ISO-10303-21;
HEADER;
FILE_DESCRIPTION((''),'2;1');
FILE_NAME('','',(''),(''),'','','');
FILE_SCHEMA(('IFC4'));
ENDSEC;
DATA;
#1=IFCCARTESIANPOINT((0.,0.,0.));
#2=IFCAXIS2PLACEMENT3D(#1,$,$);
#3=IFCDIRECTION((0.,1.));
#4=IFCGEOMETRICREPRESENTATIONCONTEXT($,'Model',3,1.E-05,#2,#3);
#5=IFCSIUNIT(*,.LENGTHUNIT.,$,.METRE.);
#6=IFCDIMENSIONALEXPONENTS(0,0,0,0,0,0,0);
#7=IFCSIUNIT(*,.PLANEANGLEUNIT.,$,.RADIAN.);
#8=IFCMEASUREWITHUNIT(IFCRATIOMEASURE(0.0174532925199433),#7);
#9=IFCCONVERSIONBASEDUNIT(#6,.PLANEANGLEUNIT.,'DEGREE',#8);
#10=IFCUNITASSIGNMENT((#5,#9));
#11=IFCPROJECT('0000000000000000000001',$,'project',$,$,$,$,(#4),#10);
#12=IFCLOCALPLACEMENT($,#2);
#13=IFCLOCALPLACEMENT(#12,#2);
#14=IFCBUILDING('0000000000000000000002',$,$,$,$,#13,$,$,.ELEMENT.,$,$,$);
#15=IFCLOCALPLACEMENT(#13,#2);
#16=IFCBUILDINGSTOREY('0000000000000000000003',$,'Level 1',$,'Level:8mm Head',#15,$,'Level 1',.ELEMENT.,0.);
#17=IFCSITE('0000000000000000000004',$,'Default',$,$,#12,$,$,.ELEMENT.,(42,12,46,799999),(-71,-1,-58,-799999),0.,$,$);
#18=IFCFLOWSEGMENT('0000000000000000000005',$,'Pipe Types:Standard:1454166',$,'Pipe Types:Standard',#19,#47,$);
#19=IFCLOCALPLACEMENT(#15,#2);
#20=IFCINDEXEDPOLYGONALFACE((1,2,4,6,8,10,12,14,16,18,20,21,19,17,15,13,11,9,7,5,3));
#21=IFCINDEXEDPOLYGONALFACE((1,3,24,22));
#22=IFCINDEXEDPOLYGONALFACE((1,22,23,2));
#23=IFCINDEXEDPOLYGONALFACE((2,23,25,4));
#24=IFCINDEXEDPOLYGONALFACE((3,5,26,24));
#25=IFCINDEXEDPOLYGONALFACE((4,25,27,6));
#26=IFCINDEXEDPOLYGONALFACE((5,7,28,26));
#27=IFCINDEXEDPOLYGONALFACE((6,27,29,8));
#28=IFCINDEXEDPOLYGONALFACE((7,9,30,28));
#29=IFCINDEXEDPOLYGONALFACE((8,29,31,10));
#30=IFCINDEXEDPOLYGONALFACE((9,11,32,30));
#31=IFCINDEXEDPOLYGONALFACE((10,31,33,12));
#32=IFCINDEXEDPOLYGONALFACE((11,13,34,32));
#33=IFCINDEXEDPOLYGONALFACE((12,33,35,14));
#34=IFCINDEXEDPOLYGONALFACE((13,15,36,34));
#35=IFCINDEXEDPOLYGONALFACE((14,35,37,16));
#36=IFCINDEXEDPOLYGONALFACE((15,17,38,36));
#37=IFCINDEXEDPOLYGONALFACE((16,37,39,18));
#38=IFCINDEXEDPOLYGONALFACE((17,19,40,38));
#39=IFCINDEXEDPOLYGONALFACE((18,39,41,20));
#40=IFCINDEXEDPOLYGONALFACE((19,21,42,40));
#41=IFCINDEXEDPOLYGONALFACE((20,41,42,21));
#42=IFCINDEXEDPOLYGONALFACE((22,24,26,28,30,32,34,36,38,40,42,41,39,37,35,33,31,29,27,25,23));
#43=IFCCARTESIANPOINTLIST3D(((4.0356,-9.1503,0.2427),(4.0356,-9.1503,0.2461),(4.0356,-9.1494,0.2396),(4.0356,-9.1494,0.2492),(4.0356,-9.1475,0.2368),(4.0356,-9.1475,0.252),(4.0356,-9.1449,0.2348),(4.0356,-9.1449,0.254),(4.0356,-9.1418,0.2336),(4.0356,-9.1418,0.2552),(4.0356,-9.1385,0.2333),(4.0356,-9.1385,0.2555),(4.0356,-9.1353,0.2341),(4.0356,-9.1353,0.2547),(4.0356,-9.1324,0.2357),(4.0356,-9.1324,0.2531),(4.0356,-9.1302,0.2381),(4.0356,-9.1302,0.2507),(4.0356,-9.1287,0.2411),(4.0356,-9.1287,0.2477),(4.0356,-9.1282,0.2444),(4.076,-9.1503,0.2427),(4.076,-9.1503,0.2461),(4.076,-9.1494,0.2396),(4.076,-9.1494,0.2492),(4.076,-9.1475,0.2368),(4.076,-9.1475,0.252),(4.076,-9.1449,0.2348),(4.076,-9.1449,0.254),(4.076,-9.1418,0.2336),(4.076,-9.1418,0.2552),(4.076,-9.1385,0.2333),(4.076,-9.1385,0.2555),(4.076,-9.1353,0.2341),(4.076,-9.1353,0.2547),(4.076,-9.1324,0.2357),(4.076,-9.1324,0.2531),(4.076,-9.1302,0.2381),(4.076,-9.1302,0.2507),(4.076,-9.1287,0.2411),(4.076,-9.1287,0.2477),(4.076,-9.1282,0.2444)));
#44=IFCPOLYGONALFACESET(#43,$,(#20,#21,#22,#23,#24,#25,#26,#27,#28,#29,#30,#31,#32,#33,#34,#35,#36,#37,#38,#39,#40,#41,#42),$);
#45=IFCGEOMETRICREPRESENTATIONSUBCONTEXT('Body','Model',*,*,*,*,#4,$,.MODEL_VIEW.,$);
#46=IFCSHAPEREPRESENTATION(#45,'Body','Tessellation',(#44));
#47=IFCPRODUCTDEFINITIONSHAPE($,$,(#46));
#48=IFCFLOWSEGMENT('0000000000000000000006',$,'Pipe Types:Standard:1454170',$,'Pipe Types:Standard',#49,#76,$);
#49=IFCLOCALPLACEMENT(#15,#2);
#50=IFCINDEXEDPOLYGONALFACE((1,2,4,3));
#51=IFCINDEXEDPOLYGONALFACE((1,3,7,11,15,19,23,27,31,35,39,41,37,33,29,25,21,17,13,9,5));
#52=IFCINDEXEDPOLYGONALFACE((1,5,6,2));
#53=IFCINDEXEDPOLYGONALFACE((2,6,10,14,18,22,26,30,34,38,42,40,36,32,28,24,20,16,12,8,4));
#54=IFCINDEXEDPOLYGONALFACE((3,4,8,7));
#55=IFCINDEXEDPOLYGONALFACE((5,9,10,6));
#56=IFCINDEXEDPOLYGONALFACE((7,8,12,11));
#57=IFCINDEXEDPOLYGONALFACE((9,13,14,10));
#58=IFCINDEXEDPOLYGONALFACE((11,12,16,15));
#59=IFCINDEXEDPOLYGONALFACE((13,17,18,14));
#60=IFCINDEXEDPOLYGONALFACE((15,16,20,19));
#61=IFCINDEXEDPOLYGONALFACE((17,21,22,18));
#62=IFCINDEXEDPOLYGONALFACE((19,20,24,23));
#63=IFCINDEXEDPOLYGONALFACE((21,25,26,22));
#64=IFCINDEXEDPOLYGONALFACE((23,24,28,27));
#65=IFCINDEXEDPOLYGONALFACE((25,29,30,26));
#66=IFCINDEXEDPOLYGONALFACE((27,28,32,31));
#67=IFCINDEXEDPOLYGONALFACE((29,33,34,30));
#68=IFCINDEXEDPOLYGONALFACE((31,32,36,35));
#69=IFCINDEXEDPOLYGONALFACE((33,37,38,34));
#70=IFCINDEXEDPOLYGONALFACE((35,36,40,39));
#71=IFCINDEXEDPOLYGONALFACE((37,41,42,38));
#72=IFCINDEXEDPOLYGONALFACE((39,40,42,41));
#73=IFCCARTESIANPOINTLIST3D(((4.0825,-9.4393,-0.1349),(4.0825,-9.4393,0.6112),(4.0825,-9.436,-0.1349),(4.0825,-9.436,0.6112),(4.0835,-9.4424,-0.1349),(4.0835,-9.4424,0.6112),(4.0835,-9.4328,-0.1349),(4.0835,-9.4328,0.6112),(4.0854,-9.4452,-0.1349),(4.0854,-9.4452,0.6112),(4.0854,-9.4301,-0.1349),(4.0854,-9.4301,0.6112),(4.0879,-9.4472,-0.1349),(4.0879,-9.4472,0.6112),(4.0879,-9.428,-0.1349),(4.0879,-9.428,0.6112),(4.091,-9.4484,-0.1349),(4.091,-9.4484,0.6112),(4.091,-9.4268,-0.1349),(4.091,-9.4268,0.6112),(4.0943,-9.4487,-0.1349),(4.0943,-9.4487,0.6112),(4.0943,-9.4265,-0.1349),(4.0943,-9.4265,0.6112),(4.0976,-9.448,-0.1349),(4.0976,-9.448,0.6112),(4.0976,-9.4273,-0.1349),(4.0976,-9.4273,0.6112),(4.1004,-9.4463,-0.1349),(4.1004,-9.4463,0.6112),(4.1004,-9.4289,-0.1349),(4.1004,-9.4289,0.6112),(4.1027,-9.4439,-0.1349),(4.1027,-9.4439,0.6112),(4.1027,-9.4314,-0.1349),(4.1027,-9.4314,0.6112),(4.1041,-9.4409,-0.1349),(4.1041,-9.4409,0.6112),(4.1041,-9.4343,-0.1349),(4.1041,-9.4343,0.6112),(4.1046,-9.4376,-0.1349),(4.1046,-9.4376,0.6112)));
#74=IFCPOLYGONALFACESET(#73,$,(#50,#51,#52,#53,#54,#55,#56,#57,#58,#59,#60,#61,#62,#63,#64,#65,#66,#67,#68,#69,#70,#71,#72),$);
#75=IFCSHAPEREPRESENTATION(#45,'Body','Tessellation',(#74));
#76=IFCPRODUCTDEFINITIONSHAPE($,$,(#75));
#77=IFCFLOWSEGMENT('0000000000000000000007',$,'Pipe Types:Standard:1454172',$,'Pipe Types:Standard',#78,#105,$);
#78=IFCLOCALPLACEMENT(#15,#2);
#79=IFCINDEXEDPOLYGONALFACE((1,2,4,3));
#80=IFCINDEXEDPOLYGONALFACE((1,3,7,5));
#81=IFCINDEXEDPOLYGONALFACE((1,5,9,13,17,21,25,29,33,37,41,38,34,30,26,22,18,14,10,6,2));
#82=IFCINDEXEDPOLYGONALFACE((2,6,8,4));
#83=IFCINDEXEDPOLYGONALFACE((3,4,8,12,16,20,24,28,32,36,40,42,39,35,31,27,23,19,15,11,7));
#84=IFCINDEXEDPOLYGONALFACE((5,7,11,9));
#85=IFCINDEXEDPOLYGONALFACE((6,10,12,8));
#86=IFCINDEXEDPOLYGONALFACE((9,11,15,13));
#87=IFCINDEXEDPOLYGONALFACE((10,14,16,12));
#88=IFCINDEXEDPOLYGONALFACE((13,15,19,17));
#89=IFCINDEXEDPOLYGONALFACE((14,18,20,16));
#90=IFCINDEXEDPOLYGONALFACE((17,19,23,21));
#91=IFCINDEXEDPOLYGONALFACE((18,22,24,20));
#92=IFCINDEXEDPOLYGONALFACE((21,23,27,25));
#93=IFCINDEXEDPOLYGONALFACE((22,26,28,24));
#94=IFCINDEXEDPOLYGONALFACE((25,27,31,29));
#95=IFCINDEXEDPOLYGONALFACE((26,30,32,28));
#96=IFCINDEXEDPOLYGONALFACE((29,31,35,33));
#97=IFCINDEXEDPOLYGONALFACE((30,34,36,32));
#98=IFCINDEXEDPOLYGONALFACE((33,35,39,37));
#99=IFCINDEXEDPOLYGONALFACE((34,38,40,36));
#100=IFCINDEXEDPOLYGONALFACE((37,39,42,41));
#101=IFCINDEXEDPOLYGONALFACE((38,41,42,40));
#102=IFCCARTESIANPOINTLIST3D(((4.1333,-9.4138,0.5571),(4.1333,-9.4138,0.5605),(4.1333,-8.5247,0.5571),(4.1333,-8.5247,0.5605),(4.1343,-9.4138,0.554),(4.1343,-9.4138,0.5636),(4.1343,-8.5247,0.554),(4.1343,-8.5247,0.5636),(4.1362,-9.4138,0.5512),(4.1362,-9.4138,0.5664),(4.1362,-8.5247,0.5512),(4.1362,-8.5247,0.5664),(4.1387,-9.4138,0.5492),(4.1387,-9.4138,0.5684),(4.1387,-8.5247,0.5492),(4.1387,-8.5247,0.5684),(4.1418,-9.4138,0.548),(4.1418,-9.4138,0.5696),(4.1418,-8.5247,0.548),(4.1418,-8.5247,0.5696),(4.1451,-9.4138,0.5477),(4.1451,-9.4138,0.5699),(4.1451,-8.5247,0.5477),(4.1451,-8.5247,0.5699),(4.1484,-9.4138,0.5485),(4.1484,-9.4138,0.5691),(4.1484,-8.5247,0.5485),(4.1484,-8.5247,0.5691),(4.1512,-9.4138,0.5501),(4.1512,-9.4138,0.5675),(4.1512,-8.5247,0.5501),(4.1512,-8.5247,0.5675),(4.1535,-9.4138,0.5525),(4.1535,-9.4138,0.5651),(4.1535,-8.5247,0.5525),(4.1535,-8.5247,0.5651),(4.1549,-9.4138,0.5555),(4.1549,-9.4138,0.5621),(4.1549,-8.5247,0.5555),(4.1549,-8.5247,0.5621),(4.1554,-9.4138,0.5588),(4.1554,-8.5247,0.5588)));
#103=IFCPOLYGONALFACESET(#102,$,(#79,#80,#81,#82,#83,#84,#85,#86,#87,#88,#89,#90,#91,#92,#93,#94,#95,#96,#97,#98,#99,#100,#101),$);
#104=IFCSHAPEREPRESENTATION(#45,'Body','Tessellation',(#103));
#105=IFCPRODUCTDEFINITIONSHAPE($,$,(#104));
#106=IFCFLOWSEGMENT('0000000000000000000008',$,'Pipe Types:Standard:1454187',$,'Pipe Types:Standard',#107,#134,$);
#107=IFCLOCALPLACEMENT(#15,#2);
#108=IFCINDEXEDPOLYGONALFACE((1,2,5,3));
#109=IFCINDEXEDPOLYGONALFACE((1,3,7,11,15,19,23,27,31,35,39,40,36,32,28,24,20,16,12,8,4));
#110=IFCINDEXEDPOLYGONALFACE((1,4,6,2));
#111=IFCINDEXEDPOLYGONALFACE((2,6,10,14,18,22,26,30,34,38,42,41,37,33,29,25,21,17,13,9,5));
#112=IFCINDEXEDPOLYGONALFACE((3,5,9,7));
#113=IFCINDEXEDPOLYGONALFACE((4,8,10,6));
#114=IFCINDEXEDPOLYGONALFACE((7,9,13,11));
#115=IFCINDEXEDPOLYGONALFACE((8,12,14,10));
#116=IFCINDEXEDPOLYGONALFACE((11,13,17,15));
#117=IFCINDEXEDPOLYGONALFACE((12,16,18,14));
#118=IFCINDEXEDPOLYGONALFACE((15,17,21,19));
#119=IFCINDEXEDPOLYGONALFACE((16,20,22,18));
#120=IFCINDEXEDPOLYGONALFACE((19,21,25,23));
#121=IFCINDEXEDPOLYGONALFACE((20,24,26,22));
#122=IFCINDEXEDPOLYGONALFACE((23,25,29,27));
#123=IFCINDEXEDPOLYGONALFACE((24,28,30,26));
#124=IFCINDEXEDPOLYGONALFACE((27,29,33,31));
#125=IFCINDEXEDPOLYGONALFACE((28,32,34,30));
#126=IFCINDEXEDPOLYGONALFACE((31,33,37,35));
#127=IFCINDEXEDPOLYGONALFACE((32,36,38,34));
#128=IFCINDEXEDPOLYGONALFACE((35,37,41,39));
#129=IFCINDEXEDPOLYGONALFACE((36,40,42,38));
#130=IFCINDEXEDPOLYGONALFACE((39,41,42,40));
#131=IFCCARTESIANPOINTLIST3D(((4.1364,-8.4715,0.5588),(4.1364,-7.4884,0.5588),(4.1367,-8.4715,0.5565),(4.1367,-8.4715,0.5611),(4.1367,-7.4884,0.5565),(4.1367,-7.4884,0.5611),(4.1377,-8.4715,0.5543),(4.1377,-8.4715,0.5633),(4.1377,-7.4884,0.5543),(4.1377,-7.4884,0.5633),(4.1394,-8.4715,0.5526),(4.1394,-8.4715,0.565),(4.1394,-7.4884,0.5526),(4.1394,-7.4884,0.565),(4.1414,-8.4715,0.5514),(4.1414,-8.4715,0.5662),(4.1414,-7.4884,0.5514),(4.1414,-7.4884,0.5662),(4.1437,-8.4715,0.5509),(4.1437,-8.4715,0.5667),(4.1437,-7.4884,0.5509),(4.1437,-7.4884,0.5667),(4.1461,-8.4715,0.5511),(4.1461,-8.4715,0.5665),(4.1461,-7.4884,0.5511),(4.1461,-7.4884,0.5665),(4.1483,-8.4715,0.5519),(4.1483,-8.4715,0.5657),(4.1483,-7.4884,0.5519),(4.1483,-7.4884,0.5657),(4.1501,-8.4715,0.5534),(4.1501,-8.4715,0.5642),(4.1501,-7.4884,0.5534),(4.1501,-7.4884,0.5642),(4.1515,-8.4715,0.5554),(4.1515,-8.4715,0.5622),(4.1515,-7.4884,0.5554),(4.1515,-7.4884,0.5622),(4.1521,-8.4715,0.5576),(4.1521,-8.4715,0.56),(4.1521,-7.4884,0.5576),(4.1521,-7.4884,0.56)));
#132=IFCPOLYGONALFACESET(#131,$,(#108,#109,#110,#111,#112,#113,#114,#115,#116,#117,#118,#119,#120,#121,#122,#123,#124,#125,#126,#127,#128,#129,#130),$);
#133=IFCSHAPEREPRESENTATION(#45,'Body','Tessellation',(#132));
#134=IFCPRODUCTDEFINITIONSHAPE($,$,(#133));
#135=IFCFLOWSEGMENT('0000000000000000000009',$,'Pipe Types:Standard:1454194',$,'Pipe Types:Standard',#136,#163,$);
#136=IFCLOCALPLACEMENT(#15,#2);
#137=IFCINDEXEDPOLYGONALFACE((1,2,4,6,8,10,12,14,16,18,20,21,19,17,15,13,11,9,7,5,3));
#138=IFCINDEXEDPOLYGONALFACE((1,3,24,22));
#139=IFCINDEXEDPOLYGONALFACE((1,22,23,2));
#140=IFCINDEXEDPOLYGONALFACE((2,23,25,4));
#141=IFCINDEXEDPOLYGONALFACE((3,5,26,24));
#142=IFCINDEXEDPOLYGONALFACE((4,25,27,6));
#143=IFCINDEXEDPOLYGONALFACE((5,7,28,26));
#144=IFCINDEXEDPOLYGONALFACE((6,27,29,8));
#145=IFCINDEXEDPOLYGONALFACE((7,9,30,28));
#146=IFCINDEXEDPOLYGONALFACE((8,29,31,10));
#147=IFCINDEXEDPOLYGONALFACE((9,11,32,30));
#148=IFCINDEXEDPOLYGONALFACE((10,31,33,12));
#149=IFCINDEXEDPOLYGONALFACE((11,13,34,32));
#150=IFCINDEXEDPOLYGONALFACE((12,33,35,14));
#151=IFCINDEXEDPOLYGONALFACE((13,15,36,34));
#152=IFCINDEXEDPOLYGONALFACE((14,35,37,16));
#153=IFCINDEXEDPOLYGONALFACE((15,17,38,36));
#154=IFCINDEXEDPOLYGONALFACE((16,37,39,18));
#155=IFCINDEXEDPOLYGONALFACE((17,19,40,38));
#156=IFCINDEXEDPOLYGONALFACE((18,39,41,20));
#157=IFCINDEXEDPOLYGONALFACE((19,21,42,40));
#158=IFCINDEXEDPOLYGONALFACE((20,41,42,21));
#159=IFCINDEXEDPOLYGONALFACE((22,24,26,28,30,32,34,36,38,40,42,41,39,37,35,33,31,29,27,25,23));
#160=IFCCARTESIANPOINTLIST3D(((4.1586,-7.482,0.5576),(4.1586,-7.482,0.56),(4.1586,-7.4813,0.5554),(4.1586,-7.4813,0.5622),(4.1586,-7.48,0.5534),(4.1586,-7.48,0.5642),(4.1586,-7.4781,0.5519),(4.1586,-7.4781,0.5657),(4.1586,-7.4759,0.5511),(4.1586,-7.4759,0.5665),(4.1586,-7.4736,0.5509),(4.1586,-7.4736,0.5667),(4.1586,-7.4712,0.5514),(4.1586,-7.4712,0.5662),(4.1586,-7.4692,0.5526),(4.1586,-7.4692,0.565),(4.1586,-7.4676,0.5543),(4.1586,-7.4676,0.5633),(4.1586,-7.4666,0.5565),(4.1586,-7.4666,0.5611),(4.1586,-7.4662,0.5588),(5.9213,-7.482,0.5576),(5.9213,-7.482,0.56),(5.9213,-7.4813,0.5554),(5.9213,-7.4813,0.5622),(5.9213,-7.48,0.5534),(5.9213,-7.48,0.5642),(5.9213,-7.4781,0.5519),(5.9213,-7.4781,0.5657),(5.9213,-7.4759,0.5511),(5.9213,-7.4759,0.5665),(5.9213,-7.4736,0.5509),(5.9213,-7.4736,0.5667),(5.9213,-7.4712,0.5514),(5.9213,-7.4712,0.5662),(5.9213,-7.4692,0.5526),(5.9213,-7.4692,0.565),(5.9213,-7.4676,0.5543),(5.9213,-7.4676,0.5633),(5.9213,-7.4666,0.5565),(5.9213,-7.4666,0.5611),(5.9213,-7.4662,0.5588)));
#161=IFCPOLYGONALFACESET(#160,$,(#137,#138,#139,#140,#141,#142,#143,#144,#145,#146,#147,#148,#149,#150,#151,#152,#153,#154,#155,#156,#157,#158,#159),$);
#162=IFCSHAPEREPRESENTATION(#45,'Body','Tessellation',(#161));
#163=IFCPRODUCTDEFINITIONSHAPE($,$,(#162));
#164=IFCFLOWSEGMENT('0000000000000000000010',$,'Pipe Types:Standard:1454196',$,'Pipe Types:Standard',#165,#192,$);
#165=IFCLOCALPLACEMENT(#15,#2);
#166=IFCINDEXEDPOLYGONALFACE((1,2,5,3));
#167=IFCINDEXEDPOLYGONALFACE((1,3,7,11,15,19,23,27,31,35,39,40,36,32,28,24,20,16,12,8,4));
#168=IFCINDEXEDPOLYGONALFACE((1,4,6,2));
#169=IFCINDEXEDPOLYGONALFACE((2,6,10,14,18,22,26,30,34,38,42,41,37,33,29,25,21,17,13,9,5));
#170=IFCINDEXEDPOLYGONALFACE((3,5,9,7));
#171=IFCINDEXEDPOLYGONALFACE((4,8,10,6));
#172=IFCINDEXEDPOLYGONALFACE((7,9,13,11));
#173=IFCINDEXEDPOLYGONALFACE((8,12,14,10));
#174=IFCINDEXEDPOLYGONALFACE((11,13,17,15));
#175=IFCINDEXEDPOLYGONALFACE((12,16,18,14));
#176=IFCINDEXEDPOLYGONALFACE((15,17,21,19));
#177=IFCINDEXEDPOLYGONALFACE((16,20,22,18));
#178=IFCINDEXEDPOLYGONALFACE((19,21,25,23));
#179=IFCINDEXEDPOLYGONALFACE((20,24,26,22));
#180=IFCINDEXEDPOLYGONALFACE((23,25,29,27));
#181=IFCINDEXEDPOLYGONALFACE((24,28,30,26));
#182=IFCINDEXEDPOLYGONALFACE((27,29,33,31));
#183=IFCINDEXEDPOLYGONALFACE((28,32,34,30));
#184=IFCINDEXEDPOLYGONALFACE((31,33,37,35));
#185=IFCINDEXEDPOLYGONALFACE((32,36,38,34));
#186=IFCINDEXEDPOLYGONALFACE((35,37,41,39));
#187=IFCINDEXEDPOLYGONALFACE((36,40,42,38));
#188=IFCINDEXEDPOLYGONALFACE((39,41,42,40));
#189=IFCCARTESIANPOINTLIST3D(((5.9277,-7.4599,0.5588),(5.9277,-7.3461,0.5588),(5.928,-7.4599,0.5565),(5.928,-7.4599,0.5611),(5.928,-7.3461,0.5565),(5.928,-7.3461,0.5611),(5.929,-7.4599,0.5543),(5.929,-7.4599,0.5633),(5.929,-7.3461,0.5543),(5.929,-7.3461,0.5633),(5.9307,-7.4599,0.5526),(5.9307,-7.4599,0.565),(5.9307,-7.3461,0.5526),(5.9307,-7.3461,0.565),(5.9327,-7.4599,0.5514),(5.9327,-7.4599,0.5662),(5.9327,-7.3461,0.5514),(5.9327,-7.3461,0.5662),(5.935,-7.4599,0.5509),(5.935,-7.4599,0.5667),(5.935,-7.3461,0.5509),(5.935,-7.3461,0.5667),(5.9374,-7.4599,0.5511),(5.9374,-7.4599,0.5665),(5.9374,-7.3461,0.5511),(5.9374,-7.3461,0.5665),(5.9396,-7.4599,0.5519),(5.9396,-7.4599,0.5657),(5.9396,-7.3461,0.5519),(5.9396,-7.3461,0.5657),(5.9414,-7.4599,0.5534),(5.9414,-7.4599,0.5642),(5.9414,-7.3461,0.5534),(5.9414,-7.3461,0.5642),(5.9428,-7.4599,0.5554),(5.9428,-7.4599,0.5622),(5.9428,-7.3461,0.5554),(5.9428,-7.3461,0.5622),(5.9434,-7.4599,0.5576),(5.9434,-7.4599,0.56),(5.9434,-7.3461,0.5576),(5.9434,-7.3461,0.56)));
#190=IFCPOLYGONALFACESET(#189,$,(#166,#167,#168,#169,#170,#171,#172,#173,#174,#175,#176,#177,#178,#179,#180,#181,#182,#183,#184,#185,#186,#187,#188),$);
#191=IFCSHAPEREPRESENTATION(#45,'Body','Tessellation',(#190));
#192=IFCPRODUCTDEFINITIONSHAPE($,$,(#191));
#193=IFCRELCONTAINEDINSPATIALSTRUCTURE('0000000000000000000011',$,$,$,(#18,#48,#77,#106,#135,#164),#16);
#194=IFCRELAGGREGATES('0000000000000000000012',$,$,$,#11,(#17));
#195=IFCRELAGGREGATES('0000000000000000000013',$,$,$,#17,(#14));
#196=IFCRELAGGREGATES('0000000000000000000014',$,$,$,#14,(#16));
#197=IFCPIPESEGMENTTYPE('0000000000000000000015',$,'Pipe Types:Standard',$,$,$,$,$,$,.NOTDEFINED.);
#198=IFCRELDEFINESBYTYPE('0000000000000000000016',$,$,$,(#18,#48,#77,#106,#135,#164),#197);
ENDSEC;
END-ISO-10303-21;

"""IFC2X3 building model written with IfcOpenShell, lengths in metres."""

from ifc_helpers import new_model, entity, si_unit, converted_unit, direction, frame, frame_2d, origin, place, context, subcontext, project, spatial, circle, extrude, type_object, element, save


model = new_model("IFC2X3")

# Units and contexts
model_context = context("Model", 3, precision=1e-05, world=origin(), true_north=direction((0.0, 1.0)))
body_context = subcontext(model_context, "Body", "Model", "MODEL_VIEW")
ifc_project = project(units=[si_unit("LENGTHUNIT", "METRE"), converted_unit("PLANEANGLEUNIT", "DEGREE", entity("IfcRatioMeasure", 0.0174532925199433), si_unit("PLANEANGLEUNIT", "RADIAN"), dimensions=[0, 0, 0, 0, 0, 0, 0])], contexts=[model_context])

# Site, building, storey
site_placement = place(None, origin())
site = spatial("IfcSite", under=ifc_project, at=site_placement, Name="Default", CompositionType="ELEMENT", RefLatitude=(42, 12, 46, 799999), RefLongitude=(-71, -1, -58, -799999), RefElevation=0.0)
building_placement = place(site_placement, origin())
building = spatial("IfcBuilding", under=site, at=building_placement, CompositionType="ELEMENT")
storey_placement = place(building_placement, origin())
storey = spatial("IfcBuildingStorey", under=building, at=storey_placement, Name="Level 1", ObjectType="Level:8mm Head", LongName="Level 1", CompositionType="ELEMENT", Elevation=0.0)

# Flow segments
pipe_segment_type = type_object("IfcPipeSegmentType", Name="Pipe Types:Standard", PredefinedType="NOTDEFINED")
flow_segment_1_placement = place(storey_placement, origin())
element("IfcFlowSegment", 1, at=flow_segment_1_placement, inside=storey, type_object=pipe_segment_type, Name="Pipe Types:Standard:1454166", ObjectType="Pipe Types:Standard", context=body_context, shape_type="SweptSolid", body=[
    extrude(circle(Radius=0.0111, at=frame_2d((0.0, 0.0), x_axis=(1.0, 0.0))), frame((4.0356, -9.1394, 0.2444), z_axis=(1.0, 0.0, 0.0), x_axis=(0.0, 1.0, 0.0)), (0.0, 0.0, 1.0), 0.0405),
])
flow_segment_2_placement = place(storey_placement, origin())
element("IfcFlowSegment", 2, at=flow_segment_2_placement, inside=storey, type_object=pipe_segment_type, Name="Pipe Types:Standard:1454170", ObjectType="Pipe Types:Standard", context=body_context, shape_type="SweptSolid", body=[
    extrude(circle(Radius=0.0111, at=frame_2d((0.0, 0.0), x_axis=(1.0, 0.0))), frame((4.0935, -9.4376, -0.1349)), (0.0, 0.0, 1.0), 0.7461),
])
flow_segment_3_placement = place(storey_placement, origin())
element("IfcFlowSegment", 3, at=flow_segment_3_placement, inside=storey, type_object=pipe_segment_type, Name="Pipe Types:Standard:1454172", ObjectType="Pipe Types:Standard", context=body_context, shape_type="SweptSolid", body=[
    extrude(circle(Radius=0.0111, at=frame_2d((0.0, 0.0), x_axis=(1.0, 0.0))), frame((4.1443, -9.4138, 0.5588), z_axis=(0.0, 1.0, 0.0), x_axis=(1.0, 0.0, 0.0)), (0.0, 0.0, 1.0), 0.8891),
])
flow_segment_4_placement = place(storey_placement, origin())
element("IfcFlowSegment", 4, at=flow_segment_4_placement, inside=storey, type_object=pipe_segment_type, Name="Pipe Types:Standard:1454187", ObjectType="Pipe Types:Standard", context=body_context, shape_type="SweptSolid", body=[
    extrude(circle(Radius=0.0079, at=frame_2d((0.0, 0.0), x_axis=(1.0, 0.0))), frame((4.1443, -8.4715, 0.5588), z_axis=(0.0, 1.0, 0.0), x_axis=(-1.0, 0.0, 0.0)), (0.0, 0.0, 1.0), 0.983),
])
flow_segment_5_placement = place(storey_placement, origin())
element("IfcFlowSegment", 5, at=flow_segment_5_placement, inside=storey, type_object=pipe_segment_type, Name="Pipe Types:Standard:1454194", ObjectType="Pipe Types:Standard", context=body_context, shape_type="SweptSolid", body=[
    extrude(circle(Radius=0.0079, at=frame_2d((0.0, 0.0), x_axis=(1.0, 0.0))), frame((4.1586, -7.4741, 0.5588), z_axis=(1.0, 0.0, 0.0), x_axis=(0.0, 1.0, 0.0)), (0.0, 0.0, 1.0), 1.7627),
])
flow_segment_6_placement = place(storey_placement, origin())
element("IfcFlowSegment", 6, at=flow_segment_6_placement, inside=storey, type_object=pipe_segment_type, Name="Pipe Types:Standard:1454196", ObjectType="Pipe Types:Standard", context=body_context, shape_type="SweptSolid", body=[
    extrude(circle(Radius=0.0079, at=frame_2d((0.0, 0.0), x_axis=(1.0, 0.0))), frame((5.9356, -7.4599, 0.5588), z_axis=(0.0, 1.0, 0.0), x_axis=(-1.0, 0.0, 0.0)), (0.0, 0.0, 1.0), 0.1138),
])

save(model, "model.ifc")
